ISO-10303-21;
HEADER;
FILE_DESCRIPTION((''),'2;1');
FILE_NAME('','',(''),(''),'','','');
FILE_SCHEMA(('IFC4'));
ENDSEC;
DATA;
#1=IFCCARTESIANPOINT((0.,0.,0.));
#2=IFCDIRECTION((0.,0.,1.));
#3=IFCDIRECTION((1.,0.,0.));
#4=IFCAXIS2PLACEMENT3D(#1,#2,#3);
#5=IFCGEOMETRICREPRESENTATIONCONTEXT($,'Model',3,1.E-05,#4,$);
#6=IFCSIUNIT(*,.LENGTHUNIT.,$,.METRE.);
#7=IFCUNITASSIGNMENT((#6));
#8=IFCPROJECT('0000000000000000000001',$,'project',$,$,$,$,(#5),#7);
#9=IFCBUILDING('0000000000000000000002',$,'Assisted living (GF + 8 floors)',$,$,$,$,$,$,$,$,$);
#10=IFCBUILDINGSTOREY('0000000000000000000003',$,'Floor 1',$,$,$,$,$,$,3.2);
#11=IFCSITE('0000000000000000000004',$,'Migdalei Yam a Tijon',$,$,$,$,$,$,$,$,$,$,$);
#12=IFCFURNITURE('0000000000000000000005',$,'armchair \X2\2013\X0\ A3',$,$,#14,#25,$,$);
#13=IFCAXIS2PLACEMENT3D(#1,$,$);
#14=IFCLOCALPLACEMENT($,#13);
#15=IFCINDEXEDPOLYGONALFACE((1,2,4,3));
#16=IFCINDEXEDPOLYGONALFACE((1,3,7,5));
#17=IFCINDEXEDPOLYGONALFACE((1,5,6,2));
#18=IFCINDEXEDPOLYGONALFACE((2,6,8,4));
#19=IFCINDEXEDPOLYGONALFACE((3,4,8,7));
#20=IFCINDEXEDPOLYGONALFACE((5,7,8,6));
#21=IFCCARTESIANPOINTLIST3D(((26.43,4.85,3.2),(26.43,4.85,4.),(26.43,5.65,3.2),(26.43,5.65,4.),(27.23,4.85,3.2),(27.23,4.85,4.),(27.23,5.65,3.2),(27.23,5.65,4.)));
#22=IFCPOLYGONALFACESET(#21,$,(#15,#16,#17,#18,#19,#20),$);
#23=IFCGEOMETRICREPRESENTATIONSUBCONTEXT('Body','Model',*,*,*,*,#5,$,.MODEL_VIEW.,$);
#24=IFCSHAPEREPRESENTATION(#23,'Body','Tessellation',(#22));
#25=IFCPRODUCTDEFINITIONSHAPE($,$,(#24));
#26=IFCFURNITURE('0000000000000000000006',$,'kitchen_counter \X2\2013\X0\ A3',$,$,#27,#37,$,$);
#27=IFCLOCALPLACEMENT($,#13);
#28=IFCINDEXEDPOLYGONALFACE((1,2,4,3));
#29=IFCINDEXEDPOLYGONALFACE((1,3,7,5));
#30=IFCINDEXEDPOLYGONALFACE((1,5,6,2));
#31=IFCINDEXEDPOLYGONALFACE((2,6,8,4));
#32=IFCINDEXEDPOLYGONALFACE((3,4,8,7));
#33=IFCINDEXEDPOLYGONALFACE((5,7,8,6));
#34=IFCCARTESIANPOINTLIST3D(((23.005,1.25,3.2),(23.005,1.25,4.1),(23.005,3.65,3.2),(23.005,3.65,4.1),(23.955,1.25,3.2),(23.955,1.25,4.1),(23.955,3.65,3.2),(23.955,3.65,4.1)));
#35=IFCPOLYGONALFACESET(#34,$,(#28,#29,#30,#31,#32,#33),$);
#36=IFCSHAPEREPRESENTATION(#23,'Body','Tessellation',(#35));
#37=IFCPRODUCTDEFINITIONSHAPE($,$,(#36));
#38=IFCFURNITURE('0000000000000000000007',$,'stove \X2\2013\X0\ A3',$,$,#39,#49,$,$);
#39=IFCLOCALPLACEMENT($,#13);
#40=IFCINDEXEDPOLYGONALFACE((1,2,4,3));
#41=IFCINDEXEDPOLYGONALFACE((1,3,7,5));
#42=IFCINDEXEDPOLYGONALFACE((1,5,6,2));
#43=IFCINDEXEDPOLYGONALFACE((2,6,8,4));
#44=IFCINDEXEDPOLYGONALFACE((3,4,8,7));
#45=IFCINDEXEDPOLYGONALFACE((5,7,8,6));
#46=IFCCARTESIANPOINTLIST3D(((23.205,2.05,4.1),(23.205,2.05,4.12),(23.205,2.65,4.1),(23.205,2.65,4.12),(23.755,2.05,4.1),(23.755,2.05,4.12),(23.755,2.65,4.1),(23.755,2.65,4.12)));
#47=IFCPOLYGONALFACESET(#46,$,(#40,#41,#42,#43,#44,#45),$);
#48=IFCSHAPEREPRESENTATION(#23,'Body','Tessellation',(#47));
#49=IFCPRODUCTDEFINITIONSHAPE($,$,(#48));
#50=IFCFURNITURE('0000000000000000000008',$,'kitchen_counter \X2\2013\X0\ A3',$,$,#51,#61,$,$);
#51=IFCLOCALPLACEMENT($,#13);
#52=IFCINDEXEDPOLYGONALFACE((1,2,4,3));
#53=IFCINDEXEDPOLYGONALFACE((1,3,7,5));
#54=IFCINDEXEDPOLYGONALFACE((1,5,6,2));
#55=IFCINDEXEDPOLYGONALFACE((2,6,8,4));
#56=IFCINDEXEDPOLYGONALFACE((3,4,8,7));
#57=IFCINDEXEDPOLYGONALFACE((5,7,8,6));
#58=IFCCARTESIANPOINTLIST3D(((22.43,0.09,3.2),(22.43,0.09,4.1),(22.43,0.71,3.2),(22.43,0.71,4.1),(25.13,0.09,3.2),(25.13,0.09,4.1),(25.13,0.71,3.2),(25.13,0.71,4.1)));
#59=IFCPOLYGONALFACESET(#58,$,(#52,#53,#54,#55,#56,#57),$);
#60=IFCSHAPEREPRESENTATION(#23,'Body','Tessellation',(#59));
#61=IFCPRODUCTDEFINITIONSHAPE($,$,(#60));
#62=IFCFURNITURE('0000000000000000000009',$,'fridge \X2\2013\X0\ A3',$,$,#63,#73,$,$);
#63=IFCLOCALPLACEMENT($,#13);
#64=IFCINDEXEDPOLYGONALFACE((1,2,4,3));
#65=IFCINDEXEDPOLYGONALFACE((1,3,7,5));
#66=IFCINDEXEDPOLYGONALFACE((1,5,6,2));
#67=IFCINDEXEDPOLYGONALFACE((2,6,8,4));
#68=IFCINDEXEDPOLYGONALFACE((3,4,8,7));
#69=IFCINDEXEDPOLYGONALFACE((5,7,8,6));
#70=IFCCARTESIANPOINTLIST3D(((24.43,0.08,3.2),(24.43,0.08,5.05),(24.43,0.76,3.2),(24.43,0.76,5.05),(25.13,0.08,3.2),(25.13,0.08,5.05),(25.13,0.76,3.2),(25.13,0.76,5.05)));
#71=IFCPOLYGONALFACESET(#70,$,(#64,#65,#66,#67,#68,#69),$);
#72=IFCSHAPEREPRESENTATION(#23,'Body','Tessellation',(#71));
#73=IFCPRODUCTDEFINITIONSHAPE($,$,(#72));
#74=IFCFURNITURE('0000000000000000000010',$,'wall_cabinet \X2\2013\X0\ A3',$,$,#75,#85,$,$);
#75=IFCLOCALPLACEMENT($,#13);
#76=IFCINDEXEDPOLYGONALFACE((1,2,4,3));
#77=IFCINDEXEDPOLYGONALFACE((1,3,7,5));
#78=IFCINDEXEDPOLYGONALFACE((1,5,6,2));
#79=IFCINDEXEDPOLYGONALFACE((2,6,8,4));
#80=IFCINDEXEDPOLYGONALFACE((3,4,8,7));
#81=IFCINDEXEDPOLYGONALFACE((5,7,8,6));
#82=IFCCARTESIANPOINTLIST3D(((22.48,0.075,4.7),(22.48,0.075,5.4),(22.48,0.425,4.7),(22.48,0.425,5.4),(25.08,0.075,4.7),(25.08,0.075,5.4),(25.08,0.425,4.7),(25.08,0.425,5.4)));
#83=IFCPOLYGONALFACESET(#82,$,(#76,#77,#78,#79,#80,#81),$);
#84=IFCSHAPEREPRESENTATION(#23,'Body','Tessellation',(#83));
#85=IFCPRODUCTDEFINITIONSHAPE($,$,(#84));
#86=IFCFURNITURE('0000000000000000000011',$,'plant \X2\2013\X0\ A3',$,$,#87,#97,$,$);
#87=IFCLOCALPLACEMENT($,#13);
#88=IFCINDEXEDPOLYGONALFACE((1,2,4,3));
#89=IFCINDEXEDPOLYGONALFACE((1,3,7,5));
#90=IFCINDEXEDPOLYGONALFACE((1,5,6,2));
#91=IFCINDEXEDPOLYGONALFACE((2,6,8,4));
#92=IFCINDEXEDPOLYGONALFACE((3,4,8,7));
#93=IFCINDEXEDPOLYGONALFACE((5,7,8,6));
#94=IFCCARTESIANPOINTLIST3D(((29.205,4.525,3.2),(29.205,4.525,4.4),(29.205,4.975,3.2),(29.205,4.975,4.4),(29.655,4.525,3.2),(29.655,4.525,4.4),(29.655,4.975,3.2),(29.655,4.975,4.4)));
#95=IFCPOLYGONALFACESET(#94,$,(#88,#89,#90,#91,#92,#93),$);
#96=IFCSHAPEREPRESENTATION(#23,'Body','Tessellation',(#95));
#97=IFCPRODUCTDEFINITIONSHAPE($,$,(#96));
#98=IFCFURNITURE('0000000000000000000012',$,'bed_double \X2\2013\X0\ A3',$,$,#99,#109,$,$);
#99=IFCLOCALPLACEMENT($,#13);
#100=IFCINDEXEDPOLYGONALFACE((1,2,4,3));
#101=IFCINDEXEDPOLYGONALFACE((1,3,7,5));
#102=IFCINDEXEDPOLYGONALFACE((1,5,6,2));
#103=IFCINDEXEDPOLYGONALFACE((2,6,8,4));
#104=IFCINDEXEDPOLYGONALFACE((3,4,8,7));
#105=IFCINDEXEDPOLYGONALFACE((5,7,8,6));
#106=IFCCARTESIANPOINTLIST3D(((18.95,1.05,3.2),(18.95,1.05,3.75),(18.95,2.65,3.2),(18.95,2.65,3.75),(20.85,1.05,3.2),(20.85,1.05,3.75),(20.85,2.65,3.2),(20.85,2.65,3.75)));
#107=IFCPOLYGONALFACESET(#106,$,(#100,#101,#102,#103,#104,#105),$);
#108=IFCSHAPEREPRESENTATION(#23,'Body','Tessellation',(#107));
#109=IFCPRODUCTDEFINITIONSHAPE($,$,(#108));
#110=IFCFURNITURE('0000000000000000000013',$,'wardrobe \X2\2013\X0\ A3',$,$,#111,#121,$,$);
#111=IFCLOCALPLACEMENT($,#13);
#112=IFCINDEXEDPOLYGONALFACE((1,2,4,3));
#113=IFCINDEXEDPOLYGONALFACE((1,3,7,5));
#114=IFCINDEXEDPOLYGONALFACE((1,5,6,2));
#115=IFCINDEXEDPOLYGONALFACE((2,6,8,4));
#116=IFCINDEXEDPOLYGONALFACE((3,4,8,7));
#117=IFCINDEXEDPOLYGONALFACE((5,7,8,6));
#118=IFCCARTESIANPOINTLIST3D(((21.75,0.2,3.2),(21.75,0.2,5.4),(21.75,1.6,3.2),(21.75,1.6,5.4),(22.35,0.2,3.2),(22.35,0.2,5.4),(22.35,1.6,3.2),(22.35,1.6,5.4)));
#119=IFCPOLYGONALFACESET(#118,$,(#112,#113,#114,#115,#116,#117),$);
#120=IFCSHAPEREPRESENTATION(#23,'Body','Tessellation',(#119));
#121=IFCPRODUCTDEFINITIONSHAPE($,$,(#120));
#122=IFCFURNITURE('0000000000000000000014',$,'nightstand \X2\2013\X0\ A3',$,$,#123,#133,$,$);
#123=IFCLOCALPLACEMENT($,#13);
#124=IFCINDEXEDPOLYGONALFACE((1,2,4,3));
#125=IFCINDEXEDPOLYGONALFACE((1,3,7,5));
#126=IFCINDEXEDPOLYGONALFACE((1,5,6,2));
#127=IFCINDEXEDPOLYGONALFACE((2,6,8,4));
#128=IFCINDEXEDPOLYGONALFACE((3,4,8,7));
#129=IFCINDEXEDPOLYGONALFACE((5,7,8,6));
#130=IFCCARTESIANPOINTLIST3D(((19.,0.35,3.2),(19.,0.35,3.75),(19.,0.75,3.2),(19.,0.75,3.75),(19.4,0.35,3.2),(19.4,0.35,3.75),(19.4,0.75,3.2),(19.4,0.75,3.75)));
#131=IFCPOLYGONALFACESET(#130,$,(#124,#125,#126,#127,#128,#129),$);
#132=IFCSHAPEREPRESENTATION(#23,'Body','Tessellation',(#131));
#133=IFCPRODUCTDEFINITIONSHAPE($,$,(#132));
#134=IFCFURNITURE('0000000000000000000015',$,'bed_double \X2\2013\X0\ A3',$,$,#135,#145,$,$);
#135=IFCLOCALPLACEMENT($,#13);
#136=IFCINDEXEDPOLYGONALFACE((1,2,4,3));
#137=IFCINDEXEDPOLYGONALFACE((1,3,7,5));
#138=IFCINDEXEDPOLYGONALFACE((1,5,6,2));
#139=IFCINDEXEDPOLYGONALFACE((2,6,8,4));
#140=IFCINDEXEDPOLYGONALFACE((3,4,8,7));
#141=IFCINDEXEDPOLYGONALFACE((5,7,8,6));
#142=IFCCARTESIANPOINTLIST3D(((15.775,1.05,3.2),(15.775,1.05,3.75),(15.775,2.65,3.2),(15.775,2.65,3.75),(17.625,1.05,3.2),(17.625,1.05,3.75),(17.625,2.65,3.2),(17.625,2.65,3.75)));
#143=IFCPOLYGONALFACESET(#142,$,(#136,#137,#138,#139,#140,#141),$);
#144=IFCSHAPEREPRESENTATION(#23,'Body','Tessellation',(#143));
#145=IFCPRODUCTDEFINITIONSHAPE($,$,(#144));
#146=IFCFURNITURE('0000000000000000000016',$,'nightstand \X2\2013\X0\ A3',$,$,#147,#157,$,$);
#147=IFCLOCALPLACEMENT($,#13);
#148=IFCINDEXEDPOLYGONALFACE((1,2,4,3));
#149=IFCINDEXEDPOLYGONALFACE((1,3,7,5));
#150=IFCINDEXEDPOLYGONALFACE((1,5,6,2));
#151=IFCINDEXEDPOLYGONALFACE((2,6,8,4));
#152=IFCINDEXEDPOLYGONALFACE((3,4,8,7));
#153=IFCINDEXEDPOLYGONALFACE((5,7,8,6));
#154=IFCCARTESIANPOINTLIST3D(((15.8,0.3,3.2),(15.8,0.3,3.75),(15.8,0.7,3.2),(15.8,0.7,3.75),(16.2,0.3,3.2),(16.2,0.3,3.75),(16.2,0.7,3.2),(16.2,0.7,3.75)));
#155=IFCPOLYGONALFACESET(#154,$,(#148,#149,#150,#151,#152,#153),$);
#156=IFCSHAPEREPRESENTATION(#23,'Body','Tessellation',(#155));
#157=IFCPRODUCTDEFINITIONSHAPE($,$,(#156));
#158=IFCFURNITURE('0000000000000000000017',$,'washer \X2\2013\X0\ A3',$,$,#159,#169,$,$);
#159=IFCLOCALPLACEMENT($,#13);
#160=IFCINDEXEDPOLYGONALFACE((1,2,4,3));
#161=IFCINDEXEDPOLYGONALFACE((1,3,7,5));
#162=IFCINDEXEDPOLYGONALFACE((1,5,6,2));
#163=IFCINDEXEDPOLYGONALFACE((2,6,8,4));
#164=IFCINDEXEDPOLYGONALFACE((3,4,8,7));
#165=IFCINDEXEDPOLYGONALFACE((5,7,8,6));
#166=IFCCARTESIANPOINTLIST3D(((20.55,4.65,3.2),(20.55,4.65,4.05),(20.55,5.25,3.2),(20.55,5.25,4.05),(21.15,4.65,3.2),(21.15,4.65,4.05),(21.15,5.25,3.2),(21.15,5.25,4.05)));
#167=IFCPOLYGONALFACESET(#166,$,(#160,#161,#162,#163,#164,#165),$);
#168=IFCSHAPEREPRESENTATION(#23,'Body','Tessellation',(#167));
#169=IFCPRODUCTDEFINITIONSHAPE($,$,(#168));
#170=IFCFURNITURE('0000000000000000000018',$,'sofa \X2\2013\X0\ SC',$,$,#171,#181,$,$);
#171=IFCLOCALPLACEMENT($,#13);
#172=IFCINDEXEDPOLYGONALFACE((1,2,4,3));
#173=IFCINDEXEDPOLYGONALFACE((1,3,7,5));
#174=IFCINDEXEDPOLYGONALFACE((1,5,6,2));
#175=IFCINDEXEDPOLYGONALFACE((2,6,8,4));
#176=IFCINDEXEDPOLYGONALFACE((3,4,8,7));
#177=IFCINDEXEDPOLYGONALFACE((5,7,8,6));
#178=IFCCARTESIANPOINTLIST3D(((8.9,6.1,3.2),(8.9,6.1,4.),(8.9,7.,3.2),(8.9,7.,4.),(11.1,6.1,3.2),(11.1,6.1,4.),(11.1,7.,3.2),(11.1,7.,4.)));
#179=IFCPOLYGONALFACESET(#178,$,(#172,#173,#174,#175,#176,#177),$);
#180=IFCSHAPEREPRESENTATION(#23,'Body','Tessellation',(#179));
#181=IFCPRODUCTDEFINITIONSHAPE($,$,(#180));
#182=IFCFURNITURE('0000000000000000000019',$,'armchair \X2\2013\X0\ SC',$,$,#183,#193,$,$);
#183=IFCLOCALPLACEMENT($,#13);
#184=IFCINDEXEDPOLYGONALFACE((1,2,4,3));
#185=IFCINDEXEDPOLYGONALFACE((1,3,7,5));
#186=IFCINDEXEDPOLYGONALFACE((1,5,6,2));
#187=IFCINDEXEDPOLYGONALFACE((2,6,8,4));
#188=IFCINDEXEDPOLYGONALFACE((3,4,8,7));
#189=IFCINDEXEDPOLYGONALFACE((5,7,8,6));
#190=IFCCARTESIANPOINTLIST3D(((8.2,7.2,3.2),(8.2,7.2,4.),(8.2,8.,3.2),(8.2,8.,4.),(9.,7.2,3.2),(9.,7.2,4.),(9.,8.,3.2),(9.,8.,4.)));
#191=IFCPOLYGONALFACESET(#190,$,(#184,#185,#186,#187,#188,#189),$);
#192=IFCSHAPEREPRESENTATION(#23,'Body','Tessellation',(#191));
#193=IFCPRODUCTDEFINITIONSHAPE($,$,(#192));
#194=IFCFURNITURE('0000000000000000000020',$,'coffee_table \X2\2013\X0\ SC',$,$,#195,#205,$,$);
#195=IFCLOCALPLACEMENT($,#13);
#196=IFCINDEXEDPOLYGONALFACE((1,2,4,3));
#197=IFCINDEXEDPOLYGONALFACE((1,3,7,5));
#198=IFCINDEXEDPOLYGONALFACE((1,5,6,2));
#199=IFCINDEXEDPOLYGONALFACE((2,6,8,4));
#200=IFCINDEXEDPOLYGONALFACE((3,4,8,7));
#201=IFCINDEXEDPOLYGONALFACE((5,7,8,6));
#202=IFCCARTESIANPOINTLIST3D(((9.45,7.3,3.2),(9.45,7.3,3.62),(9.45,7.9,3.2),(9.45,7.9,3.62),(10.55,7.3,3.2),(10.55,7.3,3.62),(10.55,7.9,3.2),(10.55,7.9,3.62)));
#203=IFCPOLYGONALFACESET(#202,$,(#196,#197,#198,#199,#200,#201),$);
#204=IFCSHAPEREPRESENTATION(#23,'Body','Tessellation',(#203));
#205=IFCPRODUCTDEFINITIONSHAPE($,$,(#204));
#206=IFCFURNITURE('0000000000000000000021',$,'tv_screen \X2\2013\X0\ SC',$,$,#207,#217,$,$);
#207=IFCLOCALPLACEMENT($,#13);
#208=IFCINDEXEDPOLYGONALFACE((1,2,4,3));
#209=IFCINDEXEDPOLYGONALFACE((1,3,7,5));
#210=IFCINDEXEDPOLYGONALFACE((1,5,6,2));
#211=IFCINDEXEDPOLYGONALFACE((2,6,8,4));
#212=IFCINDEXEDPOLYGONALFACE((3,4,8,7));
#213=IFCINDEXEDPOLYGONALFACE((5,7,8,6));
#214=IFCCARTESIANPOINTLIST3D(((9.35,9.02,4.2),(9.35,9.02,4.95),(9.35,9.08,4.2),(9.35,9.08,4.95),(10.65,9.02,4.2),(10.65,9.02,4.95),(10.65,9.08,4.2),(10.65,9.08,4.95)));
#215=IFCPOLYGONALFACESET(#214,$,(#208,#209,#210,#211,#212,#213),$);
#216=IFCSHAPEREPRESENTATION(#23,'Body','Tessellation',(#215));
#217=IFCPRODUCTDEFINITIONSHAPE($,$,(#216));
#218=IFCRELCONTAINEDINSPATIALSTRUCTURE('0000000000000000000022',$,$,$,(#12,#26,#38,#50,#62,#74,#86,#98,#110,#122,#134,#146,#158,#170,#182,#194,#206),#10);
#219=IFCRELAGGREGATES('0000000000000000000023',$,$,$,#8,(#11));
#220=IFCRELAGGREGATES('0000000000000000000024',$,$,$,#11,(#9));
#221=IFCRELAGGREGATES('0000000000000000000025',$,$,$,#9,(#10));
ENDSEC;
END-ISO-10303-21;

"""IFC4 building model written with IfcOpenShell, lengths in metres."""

from ifc_helpers import new_model, si_unit, frame, origin_with_axes, context, subcontext, project, spatial, line, indexed_curve, outline, extrude, element, save


model = new_model("IFC4")

# Units and contexts
model_context = context("Model", 3, precision=1e-05, world=origin_with_axes())
body_context = subcontext(model_context, "Body", "Model", "MODEL_VIEW")
ifc_project = project(units=[si_unit("LENGTHUNIT", "METRE")], contexts=[model_context])

# Site, building, storey
site = spatial("IfcSite", under=ifc_project, Name="Migdalei Yam a Tijon")
building = spatial("IfcBuilding", under=site, Name="Assisted living (GF + 8 floors)")
storey = spatial("IfcBuildingStorey", under=building, Name="Floor 1", Elevation=3.2)

# Furniture
element("IfcFurniture", 1, inside=storey, Name="armchair – A3", context=body_context, shape_type="SweptSolid", body=[
    extrude(outline(indexed_curve([(0.0, 0.0), (0.8, 0.0), (0.8, 0.8), (0.0, 0.8)], segments=[line(1, 2, 3, 4, 1)])), frame((26.43, 4.85, 3.2), z_axis=(0.0, 0.0, 1.0), x_axis=(1.0, 0.0, 0.0)), (0.0, 0.0, 1.0), 0.8),
])
element("IfcFurniture", 2, inside=storey, Name="kitchen_counter – A3", context=body_context, shape_type="SweptSolid", body=[
    extrude(outline(indexed_curve([(0.0, 0.0), (0.95, 0.0), (0.95, 2.4), (0.0, 2.4)], segments=[line(1, 2, 3, 4, 1)])), frame((23.005, 1.25, 3.2), z_axis=(0.0, 0.0, 1.0), x_axis=(1.0, 0.0, 0.0)), (0.0, 0.0, 1.0), 0.9),
])
element("IfcFurniture", 3, inside=storey, Name="stove – A3", context=body_context, shape_type="SweptSolid", body=[
    extrude(outline(indexed_curve([(0.0, 0.0), (0.55, 0.0), (0.55, 0.6), (0.0, 0.6)], segments=[line(1, 2, 3, 4, 1)])), frame((23.205, 2.05, 4.1), z_axis=(0.0, 0.0, 1.0), x_axis=(1.0, 0.0, 0.0)), (0.0, 0.0, 1.0), 0.02),
])
element("IfcFurniture", 4, inside=storey, Name="kitchen_counter – A3", context=body_context, shape_type="SweptSolid", body=[
    extrude(outline(indexed_curve([(0.0, 0.0), (2.7, 0.0), (2.7, 0.62), (0.0, 0.62)], segments=[line(1, 2, 3, 4, 1)])), frame((22.43, 0.09, 3.2), z_axis=(0.0, 0.0, 1.0), x_axis=(1.0, 0.0, 0.0)), (0.0, 0.0, 1.0), 0.9),
])
element("IfcFurniture", 5, inside=storey, Name="fridge – A3", context=body_context, shape_type="SweptSolid", body=[
    extrude(outline(indexed_curve([(0.0, 0.0), (0.7, 0.0), (0.7, 0.68), (0.0, 0.68)], segments=[line(1, 2, 3, 4, 1)])), frame((24.43, 0.08, 3.2), z_axis=(0.0, 0.0, 1.0), x_axis=(1.0, 0.0, 0.0)), (0.0, 0.0, 1.0), 1.85),
])
element("IfcFurniture", 6, inside=storey, Name="wall_cabinet – A3", context=body_context, shape_type="SweptSolid", body=[
    extrude(outline(indexed_curve([(0.0, 0.0), (2.6, 0.0), (2.6, 0.35), (0.0, 0.35)], segments=[line(1, 2, 3, 4, 1)])), frame((22.48, 0.075, 4.7), z_axis=(0.0, 0.0, 1.0), x_axis=(1.0, 0.0, 0.0)), (0.0, 0.0, 1.0), 0.7),
])
element("IfcFurniture", 7, inside=storey, Name="plant – A3", context=body_context, shape_type="SweptSolid", body=[
    extrude(outline(indexed_curve([(0.0, 0.0), (0.45, 0.0), (0.45, 0.45), (0.0, 0.45)], segments=[line(1, 2, 3, 4, 1)])), frame((29.205, 4.525, 3.2), z_axis=(0.0, 0.0, 1.0), x_axis=(1.0, 0.0, 0.0)), (0.0, 0.0, 1.0), 1.2),
])
element("IfcFurniture", 8, inside=storey, Name="bed_double – A3", context=body_context, shape_type="SweptSolid", body=[
    extrude(outline(indexed_curve([(0.0, 0.0), (1.9, 0.0), (1.9, 1.6), (0.0, 1.6)], segments=[line(1, 2, 3, 4, 1)])), frame((18.95, 1.05, 3.2), z_axis=(0.0, 0.0, 1.0), x_axis=(1.0, 0.0, 0.0)), (0.0, 0.0, 1.0), 0.55),
])
element("IfcFurniture", 9, inside=storey, Name="wardrobe – A3", context=body_context, shape_type="SweptSolid", body=[
    extrude(outline(indexed_curve([(0.0, 0.0), (0.6, 0.0), (0.6, 1.4), (0.0, 1.4)], segments=[line(1, 2, 3, 4, 1)])), frame((21.75, 0.2, 3.2), z_axis=(0.0, 0.0, 1.0), x_axis=(1.0, 0.0, 0.0)), (0.0, 0.0, 1.0), 2.2),
])
element("IfcFurniture", 10, inside=storey, Name="nightstand – A3", context=body_context, shape_type="SweptSolid", body=[
    extrude(outline(indexed_curve([(0.0, 0.0), (0.4, 0.0), (0.4, 0.4), (0.0, 0.4)], segments=[line(1, 2, 3, 4, 1)])), frame((19.0, 0.35, 3.2), z_axis=(0.0, 0.0, 1.0), x_axis=(1.0, 0.0, 0.0)), (0.0, 0.0, 1.0), 0.55),
])
element("IfcFurniture", 11, inside=storey, Name="bed_double – A3", context=body_context, shape_type="SweptSolid", body=[
    extrude(outline(indexed_curve([(0.0, 0.0), (1.85, 0.0), (1.85, 1.6), (0.0, 1.6)], segments=[line(1, 2, 3, 4, 1)])), frame((15.775, 1.05, 3.2), z_axis=(0.0, 0.0, 1.0), x_axis=(1.0, 0.0, 0.0)), (0.0, 0.0, 1.0), 0.55),
])
element("IfcFurniture", 12, inside=storey, Name="nightstand – A3", context=body_context, shape_type="SweptSolid", body=[
    extrude(outline(indexed_curve([(0.0, 0.0), (0.4, 0.0), (0.4, 0.4), (0.0, 0.4)], segments=[line(1, 2, 3, 4, 1)])), frame((15.8, 0.3, 3.2), z_axis=(0.0, 0.0, 1.0), x_axis=(1.0, 0.0, 0.0)), (0.0, 0.0, 1.0), 0.55),
])
element("IfcFurniture", 13, inside=storey, Name="washer – A3", context=body_context, shape_type="SweptSolid", body=[
    extrude(outline(indexed_curve([(0.0, 0.0), (0.6, 0.0), (0.6, 0.6), (0.0, 0.6)], segments=[line(1, 2, 3, 4, 1)])), frame((20.55, 4.65, 3.2), z_axis=(0.0, 0.0, 1.0), x_axis=(1.0, 0.0, 0.0)), (0.0, 0.0, 1.0), 0.85),
])
element("IfcFurniture", 14, inside=storey, Name="sofa – SC", context=body_context, shape_type="SweptSolid", body=[
    extrude(outline(indexed_curve([(0.0, 0.0), (2.2, 0.0), (2.2, 0.9), (0.0, 0.9)], segments=[line(1, 2, 3, 4, 1)])), frame((8.9, 6.1, 3.2), z_axis=(0.0, 0.0, 1.0), x_axis=(1.0, 0.0, 0.0)), (0.0, 0.0, 1.0), 0.8),
])
element("IfcFurniture", 15, inside=storey, Name="armchair – SC", context=body_context, shape_type="SweptSolid", body=[
    extrude(outline(indexed_curve([(0.0, 0.0), (0.8, 0.0), (0.8, 0.8), (0.0, 0.8)], segments=[line(1, 2, 3, 4, 1)])), frame((8.2, 7.2, 3.2), z_axis=(0.0, 0.0, 1.0), x_axis=(1.0, 0.0, 0.0)), (0.0, 0.0, 1.0), 0.8),
])
element("IfcFurniture", 16, inside=storey, Name="coffee_table – SC", context=body_context, shape_type="SweptSolid", body=[
    extrude(outline(indexed_curve([(0.0, 0.0), (1.1, 0.0), (1.1, 0.6), (0.0, 0.6)], segments=[line(1, 2, 3, 4, 1)])), frame((9.45, 7.3, 3.2), z_axis=(0.0, 0.0, 1.0), x_axis=(1.0, 0.0, 0.0)), (0.0, 0.0, 1.0), 0.42),
])
element("IfcFurniture", 17, inside=storey, Name="tv_screen – SC", context=body_context, shape_type="SweptSolid", body=[
    extrude(outline(indexed_curve([(0.0, 0.0), (1.3, 0.0), (1.3, 0.06), (0.0, 0.06)], segments=[line(1, 2, 3, 4, 1)])), frame((9.35, 9.02, 4.2), z_axis=(0.0, 0.0, 1.0), x_axis=(1.0, 0.0, 0.0)), (0.0, 0.0, 1.0), 0.75),
])

save(model, "model.ifc")
